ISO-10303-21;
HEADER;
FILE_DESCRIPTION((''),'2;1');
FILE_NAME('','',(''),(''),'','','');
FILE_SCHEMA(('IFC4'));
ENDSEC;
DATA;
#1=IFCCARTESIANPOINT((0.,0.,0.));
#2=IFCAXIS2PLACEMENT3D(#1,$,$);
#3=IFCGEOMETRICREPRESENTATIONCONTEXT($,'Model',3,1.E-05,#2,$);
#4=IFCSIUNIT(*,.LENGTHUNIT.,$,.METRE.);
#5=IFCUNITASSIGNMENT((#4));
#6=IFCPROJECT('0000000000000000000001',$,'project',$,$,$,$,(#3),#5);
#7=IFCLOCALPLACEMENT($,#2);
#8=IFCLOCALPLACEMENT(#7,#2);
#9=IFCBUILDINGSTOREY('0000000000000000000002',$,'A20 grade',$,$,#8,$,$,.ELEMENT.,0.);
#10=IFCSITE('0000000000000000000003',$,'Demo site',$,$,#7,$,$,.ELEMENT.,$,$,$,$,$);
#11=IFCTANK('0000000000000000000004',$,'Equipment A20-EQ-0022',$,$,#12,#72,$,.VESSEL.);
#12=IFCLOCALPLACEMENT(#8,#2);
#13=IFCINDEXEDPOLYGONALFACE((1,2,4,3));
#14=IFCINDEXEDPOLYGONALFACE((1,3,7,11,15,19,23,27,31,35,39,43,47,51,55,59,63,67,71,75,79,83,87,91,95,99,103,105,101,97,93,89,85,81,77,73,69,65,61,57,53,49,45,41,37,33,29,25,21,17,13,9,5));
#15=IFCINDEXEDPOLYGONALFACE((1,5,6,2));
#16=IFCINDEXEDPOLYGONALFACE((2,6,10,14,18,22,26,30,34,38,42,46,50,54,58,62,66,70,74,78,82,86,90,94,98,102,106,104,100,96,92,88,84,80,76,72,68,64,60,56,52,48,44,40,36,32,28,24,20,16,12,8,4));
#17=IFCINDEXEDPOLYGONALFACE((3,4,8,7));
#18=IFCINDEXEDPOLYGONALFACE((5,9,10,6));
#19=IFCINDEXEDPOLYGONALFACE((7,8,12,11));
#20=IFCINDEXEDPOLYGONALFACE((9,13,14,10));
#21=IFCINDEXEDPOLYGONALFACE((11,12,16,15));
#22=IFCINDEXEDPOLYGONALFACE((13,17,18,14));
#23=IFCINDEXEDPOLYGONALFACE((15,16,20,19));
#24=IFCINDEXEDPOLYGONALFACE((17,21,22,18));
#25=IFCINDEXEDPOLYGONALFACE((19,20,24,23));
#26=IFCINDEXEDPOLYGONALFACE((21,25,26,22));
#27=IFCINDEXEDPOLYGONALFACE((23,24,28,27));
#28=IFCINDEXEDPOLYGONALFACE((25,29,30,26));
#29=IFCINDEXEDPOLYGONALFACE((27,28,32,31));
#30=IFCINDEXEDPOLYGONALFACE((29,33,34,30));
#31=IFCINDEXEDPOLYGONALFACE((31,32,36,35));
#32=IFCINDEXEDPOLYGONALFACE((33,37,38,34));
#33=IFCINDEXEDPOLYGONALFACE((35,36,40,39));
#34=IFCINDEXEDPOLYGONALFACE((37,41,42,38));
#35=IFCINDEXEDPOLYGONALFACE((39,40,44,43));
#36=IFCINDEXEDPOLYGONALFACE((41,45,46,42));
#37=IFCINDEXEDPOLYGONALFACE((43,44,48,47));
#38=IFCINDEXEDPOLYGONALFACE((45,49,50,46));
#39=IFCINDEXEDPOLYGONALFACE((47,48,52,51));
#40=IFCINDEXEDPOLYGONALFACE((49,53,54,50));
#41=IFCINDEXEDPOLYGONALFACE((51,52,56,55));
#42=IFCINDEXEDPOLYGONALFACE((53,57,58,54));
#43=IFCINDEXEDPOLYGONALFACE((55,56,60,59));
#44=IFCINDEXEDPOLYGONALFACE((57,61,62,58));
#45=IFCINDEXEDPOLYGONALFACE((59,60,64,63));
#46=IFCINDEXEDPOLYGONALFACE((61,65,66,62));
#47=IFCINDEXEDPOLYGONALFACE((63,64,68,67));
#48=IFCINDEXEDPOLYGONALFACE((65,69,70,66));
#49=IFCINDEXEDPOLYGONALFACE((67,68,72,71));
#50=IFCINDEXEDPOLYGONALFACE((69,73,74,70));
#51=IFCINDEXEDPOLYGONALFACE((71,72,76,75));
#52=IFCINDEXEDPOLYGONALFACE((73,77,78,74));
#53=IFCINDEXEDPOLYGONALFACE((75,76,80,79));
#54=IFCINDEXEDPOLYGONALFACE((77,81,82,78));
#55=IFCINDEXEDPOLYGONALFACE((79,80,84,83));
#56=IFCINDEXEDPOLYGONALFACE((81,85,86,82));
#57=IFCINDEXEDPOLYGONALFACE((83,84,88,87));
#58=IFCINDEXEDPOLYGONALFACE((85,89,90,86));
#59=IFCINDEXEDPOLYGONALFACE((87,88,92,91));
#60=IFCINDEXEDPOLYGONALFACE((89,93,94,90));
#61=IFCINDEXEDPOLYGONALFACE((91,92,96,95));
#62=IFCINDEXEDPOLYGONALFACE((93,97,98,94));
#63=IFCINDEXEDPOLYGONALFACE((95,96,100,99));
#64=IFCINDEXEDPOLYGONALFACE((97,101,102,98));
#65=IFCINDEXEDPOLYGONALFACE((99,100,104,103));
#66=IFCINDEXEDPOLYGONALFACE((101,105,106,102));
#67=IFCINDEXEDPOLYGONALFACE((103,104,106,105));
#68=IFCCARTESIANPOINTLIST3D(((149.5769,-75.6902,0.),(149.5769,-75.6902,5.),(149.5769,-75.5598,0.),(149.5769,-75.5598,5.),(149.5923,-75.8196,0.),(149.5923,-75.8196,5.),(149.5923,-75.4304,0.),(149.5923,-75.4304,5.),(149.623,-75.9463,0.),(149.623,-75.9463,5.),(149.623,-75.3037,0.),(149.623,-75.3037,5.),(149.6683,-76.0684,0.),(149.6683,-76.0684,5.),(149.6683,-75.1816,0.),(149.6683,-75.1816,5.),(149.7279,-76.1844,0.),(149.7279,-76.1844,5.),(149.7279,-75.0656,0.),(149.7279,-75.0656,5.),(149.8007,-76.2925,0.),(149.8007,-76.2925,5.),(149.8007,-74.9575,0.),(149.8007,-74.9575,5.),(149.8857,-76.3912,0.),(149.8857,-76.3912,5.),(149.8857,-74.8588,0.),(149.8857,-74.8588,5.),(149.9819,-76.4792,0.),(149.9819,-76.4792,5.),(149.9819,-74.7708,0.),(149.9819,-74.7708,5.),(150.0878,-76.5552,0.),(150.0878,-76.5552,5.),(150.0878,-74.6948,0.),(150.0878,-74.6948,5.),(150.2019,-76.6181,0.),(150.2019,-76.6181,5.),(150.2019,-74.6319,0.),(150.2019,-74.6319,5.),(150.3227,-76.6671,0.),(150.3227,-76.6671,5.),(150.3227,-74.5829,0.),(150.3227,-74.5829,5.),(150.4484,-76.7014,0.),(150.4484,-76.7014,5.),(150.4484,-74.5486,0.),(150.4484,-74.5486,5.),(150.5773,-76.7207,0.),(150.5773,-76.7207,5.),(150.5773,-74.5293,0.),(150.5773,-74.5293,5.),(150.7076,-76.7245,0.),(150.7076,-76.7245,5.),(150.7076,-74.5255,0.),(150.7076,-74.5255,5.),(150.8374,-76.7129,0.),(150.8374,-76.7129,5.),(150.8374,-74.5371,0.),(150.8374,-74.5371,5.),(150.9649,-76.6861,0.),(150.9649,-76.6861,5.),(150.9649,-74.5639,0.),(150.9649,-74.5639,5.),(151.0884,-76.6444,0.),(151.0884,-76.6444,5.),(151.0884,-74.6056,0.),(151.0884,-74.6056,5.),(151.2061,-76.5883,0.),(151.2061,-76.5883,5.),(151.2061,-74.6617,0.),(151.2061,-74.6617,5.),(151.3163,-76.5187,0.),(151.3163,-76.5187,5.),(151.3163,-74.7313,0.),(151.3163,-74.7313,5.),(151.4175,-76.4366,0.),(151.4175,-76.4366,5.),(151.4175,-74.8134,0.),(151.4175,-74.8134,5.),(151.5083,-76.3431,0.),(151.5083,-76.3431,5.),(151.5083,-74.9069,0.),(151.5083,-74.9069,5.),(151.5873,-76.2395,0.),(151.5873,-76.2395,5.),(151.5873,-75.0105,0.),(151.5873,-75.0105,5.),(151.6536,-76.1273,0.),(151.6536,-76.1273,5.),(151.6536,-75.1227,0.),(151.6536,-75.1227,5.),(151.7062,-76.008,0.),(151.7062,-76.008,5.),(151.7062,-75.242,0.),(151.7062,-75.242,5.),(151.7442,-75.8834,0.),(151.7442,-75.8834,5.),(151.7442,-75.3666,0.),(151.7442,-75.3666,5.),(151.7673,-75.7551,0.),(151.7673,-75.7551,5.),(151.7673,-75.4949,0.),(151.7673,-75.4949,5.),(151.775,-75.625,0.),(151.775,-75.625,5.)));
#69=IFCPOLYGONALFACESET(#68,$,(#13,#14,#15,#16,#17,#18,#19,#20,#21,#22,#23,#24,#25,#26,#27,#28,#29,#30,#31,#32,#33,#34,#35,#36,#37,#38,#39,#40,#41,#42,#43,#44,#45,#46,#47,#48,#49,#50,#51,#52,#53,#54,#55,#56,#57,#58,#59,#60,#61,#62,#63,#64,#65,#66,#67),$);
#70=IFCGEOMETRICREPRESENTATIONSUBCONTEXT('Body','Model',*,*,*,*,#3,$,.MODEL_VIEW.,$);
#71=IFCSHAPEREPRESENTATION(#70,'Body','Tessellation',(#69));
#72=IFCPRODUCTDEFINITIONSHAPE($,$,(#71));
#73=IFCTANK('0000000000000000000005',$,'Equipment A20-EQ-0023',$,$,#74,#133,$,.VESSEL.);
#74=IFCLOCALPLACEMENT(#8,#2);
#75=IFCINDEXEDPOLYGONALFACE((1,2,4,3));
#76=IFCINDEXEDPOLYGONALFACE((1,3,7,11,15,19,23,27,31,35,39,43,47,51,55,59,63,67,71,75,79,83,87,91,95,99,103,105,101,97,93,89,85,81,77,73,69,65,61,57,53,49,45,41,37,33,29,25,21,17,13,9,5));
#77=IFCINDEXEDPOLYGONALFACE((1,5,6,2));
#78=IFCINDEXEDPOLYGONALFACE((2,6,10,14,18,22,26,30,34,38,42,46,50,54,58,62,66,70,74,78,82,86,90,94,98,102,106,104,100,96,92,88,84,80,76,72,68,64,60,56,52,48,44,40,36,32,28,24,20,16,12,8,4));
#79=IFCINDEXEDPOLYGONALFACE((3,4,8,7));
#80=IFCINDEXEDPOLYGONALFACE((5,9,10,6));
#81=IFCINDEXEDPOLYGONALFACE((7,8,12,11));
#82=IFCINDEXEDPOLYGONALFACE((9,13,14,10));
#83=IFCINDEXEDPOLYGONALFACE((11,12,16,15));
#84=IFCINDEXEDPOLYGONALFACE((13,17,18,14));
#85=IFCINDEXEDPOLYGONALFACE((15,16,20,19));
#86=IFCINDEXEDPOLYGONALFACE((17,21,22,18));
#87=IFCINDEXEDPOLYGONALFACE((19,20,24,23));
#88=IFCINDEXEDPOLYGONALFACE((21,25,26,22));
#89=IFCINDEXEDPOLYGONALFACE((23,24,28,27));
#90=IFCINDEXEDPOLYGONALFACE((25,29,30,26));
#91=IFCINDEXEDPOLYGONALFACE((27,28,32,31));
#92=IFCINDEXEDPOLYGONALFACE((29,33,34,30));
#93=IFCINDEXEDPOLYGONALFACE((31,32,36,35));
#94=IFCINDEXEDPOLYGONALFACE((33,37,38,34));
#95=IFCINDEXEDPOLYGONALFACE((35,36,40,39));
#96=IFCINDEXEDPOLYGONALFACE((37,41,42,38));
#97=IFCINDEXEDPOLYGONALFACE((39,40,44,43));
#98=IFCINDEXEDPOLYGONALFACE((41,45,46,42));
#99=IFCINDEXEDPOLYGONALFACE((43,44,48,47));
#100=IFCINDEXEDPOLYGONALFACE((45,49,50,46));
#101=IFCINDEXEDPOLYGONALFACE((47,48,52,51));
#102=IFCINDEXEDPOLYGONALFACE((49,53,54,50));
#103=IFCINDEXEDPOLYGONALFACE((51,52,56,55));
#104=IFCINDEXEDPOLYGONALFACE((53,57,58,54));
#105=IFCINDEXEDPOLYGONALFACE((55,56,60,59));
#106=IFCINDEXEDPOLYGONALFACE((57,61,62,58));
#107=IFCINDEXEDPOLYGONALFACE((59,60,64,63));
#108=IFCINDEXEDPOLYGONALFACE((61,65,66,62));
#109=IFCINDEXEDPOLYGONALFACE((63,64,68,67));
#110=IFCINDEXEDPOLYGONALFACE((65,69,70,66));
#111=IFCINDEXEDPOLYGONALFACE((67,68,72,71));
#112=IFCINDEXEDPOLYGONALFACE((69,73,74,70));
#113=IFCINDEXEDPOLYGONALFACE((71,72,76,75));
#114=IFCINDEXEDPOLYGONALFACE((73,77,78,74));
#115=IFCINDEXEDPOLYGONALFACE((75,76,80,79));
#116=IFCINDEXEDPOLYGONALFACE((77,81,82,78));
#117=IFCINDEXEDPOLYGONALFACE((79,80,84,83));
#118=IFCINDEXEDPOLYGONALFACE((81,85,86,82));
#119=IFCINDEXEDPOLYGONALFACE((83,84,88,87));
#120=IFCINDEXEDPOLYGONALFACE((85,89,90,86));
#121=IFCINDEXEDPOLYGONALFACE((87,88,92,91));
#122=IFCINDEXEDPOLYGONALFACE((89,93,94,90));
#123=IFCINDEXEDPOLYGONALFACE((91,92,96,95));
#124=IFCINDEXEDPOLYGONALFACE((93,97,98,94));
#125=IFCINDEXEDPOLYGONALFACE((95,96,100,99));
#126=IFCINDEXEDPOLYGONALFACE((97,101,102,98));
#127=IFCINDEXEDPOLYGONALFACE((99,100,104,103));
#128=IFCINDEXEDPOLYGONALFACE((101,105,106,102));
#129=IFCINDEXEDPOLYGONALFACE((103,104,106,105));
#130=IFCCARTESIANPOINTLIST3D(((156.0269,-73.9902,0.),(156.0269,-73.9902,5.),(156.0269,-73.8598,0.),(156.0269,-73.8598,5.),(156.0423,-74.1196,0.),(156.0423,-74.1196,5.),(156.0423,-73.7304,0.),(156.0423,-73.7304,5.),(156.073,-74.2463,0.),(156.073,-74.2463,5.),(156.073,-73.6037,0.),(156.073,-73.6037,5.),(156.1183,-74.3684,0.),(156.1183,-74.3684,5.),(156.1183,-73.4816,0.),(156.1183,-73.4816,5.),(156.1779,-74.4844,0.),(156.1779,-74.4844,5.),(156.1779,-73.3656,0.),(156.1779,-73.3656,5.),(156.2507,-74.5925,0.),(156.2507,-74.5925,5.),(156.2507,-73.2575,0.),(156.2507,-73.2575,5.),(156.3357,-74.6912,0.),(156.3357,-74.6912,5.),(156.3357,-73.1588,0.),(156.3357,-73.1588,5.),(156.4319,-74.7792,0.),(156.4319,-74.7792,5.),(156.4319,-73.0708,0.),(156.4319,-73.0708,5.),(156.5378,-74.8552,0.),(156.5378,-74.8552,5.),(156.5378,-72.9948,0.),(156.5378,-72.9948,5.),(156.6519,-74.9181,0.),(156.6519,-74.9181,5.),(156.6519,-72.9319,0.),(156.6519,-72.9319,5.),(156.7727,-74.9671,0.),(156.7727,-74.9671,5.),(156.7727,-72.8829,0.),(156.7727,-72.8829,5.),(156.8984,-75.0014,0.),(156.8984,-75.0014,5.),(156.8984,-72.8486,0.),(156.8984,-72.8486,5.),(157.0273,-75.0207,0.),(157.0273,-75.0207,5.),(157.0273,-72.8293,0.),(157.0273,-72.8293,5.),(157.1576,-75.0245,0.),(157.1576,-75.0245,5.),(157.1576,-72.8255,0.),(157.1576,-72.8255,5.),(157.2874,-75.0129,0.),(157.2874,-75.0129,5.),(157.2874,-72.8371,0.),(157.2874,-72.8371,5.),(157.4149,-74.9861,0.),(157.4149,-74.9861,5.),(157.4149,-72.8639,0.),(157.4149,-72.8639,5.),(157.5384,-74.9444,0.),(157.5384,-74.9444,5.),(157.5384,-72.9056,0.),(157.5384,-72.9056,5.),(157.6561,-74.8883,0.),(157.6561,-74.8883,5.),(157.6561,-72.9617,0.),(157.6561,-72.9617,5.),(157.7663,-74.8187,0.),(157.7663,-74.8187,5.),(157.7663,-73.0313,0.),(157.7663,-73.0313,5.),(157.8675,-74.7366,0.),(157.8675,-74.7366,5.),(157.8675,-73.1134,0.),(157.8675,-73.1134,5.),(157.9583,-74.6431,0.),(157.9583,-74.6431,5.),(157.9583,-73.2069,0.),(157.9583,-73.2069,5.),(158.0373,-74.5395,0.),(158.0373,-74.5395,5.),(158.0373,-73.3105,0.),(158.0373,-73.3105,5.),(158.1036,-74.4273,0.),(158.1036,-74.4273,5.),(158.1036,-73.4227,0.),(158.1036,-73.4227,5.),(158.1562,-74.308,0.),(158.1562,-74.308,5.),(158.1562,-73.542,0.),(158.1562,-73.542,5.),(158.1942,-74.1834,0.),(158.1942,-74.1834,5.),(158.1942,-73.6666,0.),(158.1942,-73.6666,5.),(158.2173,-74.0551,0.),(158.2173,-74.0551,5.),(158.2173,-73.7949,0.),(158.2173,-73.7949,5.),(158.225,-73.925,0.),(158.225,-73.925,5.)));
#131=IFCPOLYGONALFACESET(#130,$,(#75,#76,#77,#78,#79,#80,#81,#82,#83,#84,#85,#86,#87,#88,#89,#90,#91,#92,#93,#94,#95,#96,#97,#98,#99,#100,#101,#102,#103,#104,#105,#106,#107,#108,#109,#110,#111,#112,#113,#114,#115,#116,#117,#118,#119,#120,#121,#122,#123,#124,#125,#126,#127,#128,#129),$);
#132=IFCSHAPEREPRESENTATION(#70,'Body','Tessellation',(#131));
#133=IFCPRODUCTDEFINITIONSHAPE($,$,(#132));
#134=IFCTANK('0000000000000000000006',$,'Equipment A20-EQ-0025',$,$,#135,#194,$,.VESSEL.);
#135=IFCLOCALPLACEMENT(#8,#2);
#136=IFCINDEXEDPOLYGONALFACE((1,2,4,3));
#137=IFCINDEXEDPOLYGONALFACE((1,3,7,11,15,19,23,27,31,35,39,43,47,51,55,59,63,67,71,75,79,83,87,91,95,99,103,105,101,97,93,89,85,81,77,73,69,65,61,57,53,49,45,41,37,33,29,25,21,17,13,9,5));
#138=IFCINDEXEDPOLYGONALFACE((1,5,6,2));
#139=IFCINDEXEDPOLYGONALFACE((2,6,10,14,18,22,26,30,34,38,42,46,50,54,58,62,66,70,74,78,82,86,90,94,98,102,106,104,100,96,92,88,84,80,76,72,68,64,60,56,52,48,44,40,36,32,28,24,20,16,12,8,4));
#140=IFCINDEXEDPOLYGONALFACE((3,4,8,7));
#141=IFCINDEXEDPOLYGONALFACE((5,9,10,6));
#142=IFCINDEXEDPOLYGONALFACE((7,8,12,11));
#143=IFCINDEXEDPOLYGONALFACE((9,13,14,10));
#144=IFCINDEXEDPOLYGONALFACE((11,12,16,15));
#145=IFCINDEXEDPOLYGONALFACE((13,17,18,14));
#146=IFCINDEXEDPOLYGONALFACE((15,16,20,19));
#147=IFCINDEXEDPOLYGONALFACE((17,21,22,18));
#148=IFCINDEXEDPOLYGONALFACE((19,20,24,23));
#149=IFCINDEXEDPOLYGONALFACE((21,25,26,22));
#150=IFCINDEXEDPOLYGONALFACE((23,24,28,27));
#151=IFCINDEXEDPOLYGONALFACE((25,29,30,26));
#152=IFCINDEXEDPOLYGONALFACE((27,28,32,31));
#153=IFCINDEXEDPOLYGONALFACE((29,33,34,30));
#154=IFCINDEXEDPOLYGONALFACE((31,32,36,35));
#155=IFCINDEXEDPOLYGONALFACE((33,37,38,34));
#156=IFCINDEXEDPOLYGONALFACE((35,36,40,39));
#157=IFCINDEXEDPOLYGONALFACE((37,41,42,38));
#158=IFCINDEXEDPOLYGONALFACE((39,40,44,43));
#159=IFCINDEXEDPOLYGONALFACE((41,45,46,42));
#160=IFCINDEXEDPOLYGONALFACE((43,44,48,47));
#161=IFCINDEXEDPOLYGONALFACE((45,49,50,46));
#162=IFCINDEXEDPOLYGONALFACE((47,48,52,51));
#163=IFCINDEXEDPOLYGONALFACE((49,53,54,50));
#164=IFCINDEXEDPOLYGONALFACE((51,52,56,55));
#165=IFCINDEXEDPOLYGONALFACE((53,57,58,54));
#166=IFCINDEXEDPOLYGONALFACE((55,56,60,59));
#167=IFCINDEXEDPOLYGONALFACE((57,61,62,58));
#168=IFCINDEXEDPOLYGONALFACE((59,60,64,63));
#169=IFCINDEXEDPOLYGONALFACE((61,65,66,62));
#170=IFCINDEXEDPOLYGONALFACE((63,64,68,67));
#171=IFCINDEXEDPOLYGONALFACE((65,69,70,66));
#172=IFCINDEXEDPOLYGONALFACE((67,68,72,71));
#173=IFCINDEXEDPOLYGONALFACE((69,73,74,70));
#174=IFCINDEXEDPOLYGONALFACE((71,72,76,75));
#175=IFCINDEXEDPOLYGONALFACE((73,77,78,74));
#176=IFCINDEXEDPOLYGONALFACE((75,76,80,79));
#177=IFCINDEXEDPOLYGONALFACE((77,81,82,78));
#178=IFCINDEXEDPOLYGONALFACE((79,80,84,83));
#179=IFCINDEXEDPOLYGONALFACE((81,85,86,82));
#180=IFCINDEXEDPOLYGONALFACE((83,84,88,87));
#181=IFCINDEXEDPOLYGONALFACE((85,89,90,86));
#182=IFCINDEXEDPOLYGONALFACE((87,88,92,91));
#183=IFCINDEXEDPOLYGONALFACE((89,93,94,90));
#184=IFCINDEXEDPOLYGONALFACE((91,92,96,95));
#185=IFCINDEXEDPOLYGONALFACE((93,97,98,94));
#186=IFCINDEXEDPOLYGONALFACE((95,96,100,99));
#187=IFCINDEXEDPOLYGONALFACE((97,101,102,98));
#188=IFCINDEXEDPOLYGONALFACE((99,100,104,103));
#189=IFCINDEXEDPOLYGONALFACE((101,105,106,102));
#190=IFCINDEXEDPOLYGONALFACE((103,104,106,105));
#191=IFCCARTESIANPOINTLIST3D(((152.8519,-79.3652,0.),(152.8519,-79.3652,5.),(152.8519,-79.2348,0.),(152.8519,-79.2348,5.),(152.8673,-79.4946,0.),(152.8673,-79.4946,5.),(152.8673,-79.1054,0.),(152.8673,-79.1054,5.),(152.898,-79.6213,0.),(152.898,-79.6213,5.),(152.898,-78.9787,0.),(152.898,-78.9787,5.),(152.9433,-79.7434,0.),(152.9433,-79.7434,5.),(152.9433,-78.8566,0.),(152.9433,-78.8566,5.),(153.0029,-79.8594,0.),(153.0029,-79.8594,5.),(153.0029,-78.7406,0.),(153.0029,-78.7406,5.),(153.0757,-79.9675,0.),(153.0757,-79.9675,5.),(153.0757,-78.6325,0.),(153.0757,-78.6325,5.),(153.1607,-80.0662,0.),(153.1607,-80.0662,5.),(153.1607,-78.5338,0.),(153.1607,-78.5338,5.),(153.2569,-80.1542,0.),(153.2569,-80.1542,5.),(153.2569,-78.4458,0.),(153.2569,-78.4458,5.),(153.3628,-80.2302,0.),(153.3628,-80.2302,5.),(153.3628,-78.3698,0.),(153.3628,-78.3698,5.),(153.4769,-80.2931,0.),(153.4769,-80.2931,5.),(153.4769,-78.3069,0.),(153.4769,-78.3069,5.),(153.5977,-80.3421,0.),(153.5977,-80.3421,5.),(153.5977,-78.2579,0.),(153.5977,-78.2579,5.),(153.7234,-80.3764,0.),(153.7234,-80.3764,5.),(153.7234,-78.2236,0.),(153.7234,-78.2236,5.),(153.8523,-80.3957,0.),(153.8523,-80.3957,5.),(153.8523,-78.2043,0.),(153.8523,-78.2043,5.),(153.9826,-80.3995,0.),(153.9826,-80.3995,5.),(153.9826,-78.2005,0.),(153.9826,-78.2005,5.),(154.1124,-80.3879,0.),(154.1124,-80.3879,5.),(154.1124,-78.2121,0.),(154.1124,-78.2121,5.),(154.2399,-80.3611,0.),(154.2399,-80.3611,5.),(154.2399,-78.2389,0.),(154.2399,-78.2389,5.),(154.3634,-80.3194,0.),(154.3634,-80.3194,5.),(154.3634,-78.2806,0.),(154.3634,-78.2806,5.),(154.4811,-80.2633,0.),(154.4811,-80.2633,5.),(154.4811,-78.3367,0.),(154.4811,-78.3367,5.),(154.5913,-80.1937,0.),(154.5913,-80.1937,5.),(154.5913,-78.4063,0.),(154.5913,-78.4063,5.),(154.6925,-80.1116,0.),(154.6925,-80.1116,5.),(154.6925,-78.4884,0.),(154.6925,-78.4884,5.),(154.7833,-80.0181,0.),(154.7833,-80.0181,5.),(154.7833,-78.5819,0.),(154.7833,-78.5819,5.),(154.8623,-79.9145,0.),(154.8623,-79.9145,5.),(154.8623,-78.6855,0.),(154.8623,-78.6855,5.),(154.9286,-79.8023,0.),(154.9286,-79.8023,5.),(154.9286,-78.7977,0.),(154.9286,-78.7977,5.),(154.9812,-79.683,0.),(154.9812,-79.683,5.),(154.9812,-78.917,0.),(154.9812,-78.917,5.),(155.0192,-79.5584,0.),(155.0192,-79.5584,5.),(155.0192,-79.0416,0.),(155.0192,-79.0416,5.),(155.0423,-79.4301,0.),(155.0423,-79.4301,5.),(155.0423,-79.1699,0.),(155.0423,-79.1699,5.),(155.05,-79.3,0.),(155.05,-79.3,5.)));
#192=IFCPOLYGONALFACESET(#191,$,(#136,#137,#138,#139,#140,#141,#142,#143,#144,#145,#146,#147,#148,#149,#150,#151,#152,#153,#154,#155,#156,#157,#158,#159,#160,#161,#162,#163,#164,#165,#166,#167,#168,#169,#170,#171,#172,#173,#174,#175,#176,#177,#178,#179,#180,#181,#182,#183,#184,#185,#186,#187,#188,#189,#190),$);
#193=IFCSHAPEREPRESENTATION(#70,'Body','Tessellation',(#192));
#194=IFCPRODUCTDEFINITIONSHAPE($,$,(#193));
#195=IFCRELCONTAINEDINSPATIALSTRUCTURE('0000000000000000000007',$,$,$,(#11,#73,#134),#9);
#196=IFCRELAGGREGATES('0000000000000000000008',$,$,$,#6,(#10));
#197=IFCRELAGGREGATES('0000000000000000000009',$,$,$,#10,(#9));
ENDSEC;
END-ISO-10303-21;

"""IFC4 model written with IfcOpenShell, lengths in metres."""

from ifc_helpers import new_model, si_unit, frame, origin, place, context, subcontext, project, spatial, circle, extrude, element, save


model = new_model("IFC4")

# Units and contexts
model_context = context("Model", 3, precision=1e-05, world=origin())
body_context = subcontext(model_context, "Body", "Model", "MODEL_VIEW")
ifc_project = project(units=[si_unit("LENGTHUNIT", "METRE")], contexts=[model_context])

# Site, storey
site_placement = place(None, origin())
site = spatial("IfcSite", under=ifc_project, at=site_placement, Name="Demo site", CompositionType="ELEMENT")
storey_placement = place(site_placement, origin())
storey = spatial("IfcBuildingStorey", under=site, at=storey_placement, Name="A20 grade", CompositionType="ELEMENT", Elevation=0.0)

# Tanks
for number, where, name in (
    (1, (150.675, -75.625, 0.0), "Equipment A20-EQ-0022"),
    (2, (157.125, -73.925, 0.0), "Equipment A20-EQ-0023"),
    (3, (153.95, -79.3, 0.0), "Equipment A20-EQ-0025"),
):
    element("IfcTank", number, at=place(storey_placement, frame(where)), inside=storey, Name=name, PredefinedType="VESSEL", context=body_context, shape_type="SweptSolid", body=[
        extrude(circle(Radius=1.1), origin(), (0.0, 0.0, 1.0), 5.0),
    ])

save(model, "model.ifc")
